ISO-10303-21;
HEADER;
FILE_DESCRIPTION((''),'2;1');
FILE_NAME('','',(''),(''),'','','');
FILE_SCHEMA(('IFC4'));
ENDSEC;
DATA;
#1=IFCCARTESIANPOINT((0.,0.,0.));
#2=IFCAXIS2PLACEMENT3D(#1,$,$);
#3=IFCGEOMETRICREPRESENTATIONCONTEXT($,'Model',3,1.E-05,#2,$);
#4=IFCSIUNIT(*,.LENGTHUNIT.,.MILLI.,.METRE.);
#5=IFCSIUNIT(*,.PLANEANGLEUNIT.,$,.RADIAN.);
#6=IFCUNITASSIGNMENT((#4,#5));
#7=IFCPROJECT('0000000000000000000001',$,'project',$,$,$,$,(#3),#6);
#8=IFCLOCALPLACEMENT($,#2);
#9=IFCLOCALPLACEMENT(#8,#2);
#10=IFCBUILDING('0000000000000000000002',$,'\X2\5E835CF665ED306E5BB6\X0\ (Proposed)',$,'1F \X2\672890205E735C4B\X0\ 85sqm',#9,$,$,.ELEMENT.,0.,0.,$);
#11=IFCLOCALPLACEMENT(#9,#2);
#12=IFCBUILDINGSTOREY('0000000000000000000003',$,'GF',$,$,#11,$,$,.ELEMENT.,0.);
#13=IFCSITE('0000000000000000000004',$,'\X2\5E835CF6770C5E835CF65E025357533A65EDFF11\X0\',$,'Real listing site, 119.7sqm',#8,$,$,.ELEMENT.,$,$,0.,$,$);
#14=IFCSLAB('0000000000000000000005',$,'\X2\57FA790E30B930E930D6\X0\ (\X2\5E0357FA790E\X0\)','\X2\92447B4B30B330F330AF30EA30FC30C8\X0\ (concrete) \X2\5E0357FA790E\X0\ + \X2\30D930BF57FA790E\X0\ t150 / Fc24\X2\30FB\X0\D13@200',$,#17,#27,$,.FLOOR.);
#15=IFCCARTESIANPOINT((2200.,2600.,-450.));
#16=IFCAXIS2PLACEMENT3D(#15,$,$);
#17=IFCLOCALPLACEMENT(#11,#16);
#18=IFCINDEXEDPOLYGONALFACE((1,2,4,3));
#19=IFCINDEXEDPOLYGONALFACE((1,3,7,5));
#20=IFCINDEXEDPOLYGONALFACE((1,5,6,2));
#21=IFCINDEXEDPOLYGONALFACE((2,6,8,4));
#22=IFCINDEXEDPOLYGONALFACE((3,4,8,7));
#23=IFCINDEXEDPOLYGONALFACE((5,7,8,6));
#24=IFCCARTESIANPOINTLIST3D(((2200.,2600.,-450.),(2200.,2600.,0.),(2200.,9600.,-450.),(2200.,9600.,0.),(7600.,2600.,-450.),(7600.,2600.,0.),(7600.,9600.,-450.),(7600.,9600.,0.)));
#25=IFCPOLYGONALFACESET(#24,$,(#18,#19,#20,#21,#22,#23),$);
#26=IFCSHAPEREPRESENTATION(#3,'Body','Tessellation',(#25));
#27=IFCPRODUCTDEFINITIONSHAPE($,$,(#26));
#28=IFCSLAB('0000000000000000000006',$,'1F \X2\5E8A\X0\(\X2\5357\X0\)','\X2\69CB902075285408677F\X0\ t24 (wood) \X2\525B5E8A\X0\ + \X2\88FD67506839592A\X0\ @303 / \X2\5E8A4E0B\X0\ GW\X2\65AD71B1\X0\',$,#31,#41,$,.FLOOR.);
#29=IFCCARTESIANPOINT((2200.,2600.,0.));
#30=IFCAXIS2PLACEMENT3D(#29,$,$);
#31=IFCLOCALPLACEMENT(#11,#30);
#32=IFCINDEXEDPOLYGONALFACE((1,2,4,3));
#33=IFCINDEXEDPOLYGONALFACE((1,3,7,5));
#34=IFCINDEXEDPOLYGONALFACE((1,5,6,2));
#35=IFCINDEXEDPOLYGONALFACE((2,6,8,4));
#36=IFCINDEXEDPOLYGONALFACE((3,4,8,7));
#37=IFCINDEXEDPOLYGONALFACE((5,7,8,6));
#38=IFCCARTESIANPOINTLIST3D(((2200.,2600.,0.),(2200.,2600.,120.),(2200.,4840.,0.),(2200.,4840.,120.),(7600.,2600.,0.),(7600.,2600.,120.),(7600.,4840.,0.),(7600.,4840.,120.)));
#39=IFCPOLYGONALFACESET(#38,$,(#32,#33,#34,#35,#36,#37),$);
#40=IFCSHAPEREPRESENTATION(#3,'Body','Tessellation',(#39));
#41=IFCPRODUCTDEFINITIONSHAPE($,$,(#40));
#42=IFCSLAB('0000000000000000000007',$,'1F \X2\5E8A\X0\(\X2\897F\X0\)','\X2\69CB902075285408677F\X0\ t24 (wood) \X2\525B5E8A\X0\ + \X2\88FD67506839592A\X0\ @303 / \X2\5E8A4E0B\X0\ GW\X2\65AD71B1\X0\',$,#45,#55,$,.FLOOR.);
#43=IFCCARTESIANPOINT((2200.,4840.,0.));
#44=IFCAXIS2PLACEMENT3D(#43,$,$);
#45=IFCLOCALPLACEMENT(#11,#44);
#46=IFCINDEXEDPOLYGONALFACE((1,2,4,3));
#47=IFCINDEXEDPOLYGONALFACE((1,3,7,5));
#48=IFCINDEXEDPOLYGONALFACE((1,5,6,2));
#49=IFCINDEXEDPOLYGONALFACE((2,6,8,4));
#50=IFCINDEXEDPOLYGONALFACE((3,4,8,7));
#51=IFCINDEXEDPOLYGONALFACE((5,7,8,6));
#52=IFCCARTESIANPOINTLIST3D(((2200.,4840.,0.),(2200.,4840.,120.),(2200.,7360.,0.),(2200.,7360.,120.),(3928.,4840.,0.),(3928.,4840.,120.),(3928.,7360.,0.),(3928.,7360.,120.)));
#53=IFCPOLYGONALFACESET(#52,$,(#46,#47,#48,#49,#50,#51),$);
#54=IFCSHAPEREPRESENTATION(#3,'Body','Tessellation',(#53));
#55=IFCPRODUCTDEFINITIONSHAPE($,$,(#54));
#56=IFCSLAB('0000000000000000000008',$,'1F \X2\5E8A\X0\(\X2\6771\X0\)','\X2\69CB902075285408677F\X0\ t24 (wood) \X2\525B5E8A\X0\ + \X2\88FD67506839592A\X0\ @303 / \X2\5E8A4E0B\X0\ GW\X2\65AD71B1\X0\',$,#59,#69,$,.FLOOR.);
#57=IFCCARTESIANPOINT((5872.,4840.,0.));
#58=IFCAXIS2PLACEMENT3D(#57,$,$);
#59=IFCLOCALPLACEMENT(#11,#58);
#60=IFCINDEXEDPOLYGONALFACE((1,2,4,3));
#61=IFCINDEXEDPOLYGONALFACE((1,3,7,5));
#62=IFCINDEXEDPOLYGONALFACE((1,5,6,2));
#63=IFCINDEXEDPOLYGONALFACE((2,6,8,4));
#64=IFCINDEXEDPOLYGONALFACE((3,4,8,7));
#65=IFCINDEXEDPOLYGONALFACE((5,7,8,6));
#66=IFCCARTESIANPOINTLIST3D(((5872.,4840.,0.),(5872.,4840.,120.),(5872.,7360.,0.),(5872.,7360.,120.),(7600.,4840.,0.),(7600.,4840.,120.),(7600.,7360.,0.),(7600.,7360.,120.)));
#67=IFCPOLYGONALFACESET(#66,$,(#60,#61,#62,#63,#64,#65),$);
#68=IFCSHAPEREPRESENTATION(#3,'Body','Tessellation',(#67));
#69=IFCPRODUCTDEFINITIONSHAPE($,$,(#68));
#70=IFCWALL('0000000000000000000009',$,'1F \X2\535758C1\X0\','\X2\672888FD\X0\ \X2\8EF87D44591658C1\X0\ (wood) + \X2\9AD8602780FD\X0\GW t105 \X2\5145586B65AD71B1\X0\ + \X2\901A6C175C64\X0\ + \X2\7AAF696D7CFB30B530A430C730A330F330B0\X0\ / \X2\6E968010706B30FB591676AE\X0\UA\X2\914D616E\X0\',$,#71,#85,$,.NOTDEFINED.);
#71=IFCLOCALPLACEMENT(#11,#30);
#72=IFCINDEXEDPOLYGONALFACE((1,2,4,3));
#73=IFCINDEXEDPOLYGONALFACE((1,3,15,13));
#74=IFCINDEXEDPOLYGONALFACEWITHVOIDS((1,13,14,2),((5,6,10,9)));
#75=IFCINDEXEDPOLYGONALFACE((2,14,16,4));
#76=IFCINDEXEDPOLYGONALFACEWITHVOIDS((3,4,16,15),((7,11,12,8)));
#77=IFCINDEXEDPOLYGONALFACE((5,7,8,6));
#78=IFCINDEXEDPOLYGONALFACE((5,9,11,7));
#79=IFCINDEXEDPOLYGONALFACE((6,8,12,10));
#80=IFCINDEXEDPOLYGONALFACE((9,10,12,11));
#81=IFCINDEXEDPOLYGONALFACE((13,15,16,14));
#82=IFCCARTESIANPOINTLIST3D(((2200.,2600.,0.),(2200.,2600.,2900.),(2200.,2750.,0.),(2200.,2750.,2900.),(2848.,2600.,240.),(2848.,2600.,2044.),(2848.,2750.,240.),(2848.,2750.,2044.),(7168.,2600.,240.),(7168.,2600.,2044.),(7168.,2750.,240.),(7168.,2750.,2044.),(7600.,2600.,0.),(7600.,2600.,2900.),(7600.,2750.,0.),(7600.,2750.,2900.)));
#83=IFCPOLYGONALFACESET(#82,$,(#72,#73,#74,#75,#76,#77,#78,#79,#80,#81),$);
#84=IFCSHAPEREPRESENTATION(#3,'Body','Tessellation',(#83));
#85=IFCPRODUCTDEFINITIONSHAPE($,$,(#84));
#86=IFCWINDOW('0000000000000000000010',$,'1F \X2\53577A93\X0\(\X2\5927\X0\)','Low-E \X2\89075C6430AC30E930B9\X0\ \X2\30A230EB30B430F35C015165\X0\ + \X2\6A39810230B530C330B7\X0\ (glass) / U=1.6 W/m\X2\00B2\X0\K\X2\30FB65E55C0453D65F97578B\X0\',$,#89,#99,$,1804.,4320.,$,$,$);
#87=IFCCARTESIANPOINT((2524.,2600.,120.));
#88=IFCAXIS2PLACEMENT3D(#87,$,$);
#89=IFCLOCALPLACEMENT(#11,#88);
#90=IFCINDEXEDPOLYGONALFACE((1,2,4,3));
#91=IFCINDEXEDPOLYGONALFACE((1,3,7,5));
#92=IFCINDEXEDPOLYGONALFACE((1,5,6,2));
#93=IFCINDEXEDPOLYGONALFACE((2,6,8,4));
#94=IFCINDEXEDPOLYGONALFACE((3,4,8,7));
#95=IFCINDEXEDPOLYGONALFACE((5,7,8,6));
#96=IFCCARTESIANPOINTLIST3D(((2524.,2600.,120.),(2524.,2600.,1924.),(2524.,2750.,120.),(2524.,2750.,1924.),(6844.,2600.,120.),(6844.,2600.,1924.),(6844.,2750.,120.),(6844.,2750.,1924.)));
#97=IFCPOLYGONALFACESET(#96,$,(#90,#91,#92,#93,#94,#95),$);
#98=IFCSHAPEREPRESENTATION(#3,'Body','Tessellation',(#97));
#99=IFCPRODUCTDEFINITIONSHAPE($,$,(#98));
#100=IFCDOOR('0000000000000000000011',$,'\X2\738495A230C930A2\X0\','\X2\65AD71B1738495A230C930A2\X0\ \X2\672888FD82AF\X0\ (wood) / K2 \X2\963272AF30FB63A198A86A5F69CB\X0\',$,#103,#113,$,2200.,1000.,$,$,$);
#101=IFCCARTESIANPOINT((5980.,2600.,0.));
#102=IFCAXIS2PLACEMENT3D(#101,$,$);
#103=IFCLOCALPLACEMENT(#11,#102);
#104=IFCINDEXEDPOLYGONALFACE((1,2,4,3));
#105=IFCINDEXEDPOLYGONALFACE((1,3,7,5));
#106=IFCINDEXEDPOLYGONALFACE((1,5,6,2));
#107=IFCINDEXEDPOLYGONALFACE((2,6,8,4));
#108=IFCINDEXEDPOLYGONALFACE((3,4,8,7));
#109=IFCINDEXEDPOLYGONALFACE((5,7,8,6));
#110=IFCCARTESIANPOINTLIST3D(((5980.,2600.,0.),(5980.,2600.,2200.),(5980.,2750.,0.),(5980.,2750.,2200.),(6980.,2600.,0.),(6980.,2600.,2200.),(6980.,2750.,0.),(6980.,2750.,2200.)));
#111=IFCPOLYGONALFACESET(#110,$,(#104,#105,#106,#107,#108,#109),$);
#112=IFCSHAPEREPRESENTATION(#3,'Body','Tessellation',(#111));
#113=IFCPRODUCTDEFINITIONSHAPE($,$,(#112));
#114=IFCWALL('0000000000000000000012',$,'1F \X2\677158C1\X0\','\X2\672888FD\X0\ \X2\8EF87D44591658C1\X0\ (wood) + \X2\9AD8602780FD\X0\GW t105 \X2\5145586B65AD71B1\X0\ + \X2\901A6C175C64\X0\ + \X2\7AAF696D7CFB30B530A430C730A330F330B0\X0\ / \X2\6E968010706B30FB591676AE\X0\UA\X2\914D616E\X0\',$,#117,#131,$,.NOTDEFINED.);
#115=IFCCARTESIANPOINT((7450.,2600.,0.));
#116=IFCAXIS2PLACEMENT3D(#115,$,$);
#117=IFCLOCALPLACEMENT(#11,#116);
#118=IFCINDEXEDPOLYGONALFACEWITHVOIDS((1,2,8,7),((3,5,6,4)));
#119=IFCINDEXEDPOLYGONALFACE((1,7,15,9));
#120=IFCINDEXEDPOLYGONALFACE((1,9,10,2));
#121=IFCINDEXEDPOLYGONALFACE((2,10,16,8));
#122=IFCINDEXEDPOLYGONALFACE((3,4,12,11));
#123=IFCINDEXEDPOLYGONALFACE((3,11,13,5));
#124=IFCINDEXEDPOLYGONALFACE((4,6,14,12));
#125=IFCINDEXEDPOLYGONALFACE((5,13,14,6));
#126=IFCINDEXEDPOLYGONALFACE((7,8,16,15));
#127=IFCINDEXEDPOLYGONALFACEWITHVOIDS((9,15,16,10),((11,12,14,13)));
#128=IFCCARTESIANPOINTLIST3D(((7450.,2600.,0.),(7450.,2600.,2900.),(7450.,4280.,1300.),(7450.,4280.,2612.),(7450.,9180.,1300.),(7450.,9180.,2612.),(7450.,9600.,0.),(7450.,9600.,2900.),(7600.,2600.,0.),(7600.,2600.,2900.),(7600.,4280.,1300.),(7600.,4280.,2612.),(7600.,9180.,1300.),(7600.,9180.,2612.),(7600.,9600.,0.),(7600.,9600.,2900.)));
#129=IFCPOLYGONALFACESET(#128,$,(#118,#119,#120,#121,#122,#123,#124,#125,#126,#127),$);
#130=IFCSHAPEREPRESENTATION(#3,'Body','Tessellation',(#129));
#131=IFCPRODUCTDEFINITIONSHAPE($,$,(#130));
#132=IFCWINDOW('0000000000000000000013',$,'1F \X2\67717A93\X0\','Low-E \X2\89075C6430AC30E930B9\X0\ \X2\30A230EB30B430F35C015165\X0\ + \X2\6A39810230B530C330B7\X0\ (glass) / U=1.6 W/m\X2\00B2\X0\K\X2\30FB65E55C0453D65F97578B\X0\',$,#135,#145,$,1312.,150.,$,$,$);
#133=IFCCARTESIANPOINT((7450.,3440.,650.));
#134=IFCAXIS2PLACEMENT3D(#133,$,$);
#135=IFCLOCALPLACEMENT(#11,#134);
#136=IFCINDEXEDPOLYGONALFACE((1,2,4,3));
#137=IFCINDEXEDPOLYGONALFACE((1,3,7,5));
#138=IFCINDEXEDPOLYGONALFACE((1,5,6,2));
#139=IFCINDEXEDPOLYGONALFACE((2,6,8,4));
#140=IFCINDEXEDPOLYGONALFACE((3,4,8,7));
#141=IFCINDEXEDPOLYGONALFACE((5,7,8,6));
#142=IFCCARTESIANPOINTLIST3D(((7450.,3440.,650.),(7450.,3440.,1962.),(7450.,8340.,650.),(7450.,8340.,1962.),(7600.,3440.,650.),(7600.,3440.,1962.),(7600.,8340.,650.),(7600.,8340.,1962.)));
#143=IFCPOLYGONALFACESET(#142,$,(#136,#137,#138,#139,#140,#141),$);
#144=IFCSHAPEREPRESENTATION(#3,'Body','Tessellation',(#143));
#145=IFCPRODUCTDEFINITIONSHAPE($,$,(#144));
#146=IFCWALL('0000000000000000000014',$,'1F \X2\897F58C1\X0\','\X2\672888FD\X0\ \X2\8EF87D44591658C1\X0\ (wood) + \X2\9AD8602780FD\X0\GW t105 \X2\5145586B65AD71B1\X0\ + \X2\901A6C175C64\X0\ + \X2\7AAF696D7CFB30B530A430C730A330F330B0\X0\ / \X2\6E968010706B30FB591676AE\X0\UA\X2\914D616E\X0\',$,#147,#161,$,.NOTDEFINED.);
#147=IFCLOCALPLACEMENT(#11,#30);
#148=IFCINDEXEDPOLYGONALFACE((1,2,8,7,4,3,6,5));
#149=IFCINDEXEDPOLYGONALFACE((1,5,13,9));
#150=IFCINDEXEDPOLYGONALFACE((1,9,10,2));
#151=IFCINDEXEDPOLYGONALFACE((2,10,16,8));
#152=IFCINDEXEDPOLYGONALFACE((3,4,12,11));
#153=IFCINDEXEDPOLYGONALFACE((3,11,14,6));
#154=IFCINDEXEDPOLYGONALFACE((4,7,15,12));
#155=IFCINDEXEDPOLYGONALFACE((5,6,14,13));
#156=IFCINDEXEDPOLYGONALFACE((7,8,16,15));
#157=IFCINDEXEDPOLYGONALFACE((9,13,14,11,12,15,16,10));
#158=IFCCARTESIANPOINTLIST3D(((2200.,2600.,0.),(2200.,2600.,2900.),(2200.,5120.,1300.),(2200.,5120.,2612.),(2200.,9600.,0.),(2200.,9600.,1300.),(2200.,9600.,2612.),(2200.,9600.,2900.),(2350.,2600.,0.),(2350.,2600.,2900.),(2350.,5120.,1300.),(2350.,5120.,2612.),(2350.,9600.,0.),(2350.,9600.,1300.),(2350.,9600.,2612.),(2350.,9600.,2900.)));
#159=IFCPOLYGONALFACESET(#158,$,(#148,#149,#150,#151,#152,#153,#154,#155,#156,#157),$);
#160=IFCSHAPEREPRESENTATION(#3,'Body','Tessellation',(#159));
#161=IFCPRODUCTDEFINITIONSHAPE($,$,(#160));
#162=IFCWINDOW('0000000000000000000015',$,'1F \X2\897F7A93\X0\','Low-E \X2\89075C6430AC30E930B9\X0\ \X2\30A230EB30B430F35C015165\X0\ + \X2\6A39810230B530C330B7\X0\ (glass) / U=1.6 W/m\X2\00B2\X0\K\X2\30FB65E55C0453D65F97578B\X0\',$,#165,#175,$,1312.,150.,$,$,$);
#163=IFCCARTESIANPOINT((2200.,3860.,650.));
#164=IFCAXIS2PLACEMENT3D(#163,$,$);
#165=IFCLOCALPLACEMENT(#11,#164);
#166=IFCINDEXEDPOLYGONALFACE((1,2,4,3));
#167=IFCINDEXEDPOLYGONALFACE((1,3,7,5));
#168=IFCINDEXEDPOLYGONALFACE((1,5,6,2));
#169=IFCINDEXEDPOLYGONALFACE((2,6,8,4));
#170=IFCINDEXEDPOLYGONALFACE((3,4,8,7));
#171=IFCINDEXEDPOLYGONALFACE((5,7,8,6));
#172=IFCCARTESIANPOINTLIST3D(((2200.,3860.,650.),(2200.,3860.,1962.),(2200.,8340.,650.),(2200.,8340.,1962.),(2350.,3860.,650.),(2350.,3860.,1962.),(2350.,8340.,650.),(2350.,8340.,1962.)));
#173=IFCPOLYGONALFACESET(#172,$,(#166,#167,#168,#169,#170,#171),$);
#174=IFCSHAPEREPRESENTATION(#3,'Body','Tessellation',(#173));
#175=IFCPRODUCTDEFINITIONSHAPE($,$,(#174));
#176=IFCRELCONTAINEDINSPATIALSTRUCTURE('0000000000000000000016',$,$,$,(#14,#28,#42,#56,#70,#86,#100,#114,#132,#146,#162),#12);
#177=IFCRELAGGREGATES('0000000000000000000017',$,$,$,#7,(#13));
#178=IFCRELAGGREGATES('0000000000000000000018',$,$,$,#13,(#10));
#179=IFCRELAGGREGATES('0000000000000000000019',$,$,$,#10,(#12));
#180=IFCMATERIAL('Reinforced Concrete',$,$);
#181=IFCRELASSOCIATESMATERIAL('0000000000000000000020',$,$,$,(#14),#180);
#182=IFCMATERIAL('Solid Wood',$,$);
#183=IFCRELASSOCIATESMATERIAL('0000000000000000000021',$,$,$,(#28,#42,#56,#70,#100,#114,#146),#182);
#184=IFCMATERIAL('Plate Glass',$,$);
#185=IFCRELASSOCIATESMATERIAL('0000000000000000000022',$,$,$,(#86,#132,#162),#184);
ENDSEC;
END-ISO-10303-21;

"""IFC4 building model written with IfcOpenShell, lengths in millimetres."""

from ifc_helpers import new_model, si_unit, frame, frame_2d, origin, place, context, project, spatial, rectangle, extrude, material, element, fill, save


model = new_model("IFC4")

# Units and contexts
model_context = context("Model", 3, precision=1e-05, world=origin())
ifc_project = project(units=[si_unit("LENGTHUNIT", "METRE", prefix="MILLI"), si_unit("PLANEANGLEUNIT", "RADIAN")], contexts=[model_context])

# Site, building, storey
site_placement = place(None, origin())
site = spatial("IfcSite", under=ifc_project, at=site_placement, Name="広島県広島市南区旭１", ObjectType="Real listing site, 119.7sqm", CompositionType="ELEMENT", RefElevation=0.0)
building_placement = place(site_placement, origin())
building = spatial("IfcBuilding", under=site, at=building_placement, Name="広島旭の家 (Proposed)", ObjectType="1F 木造平屋 85sqm", CompositionType="ELEMENT", ElevationOfRefHeight=0.0, ElevationOfTerrain=0.0)
storey_placement = place(building_placement, origin())
storey = spatial("IfcBuildingStorey", under=building, at=storey_placement, Name="GF", CompositionType="ELEMENT", Elevation=0.0)

# Slabs
ifc_material_1 = material(Name="Reinforced Concrete")
slab_1_placement = place(storey_placement, frame((2200.0, 2600.0, -450.0)))
element("IfcSlab", 1, at=slab_1_placement, inside=storey, material=ifc_material_1, Name="基礎スラブ (布基礎)", Description="鉄筋コンクリート (concrete) 布基礎 + ベタ基礎 t150 / Fc24・D13@200", PredefinedType="FLOOR", context=model_context, shape_type="SweptSolid", body=[
    extrude(rectangle(XDim=5400.0, YDim=7000.0, at=frame_2d((2700.0, 3500.0))), frame((2200.0, 2600.0, -450.0)), (0.0, 0.0, 1.0), 450.0),
])
ifc_material_2 = material(Name="Solid Wood")
slab_2_placement = place(storey_placement, frame((2200.0, 2600.0, 0.0)))
element("IfcSlab", 2, at=slab_2_placement, inside=storey, material=ifc_material_2, Name="1F 床(南)", Description="構造用合板 t24 (wood) 剛床 + 製材根太 @303 / 床下 GW断熱", PredefinedType="FLOOR", context=model_context, shape_type="SweptSolid", body=[
    extrude(rectangle(XDim=5400.0, YDim=2240.0, at=frame_2d((2700.0, 1120.0))), frame((2200.0, 2600.0, 0.0)), (0.0, 0.0, 1.0), 120.0),
])
slab_3_placement = place(storey_placement, frame((2200.0, 4840.0, 0.0)))
element("IfcSlab", 3, at=slab_3_placement, inside=storey, material=ifc_material_2, Name="1F 床(西)", Description="構造用合板 t24 (wood) 剛床 + 製材根太 @303 / 床下 GW断熱", PredefinedType="FLOOR", context=model_context, shape_type="SweptSolid", body=[
    extrude(rectangle(XDim=1728.0, YDim=2520.0, at=frame_2d((864.0, 1260.0))), frame((2200.0, 4840.0, 0.0)), (0.0, 0.0, 1.0), 120.0),
])
slab_4_placement = place(storey_placement, frame((5872.0, 4840.0, 0.0)))
element("IfcSlab", 4, at=slab_4_placement, inside=storey, material=ifc_material_2, Name="1F 床(東)", Description="構造用合板 t24 (wood) 剛床 + 製材根太 @303 / 床下 GW断熱", PredefinedType="FLOOR", context=model_context, shape_type="SweptSolid", body=[
    extrude(rectangle(XDim=1728.0, YDim=2520.0, at=frame_2d((864.0, 1260.0))), frame((5872.0, 4840.0, 0.0)), (0.0, 0.0, 1.0), 120.0),
])

# Wall, openings, window, door
wall_1_placement = place(storey_placement, frame((2200.0, 2600.0, 0.0)))
wall_1 = element("IfcWall", 5, at=wall_1_placement, inside=storey, material=ifc_material_2, Name="1F 南壁", Description="木製 軸組外壁 (wood) + 高性能GW t105 充填断熱 + 通気層 + 窯業系サイディング / 準耐火・外皮UA配慮", PredefinedType="NOTDEFINED", context=model_context, shape_type="SweptSolid", body=[
    extrude(rectangle(XDim=5400.0, YDim=150.0, at=frame_2d((2700.0, 75.0))), frame((2200.0, 2600.0, 0.0)), (0.0, 0.0, 1.0), 2900.0),
])
opening_1_placement = place(storey_placement, frame((2524.0, 2600.0, 120.0)))
opening_1 = element("IfcOpeningElement", 6, at=opening_1_placement, cuts=wall_1, PredefinedType="NOTDEFINED", context=model_context, shape_type="SweptSolid", body=[
    extrude(rectangle(XDim=4320.0, YDim=150.0, at=frame_2d((2160.0, 75.0))), frame((2524.0, 2600.0, 120.0)), (0.0, 0.0, 1.0), 1804.0),
])
opening_2_placement = place(storey_placement, frame((5980.0, 2600.0, 0.0)))
opening_2 = element("IfcOpeningElement", 7, at=opening_2_placement, cuts=wall_1, PredefinedType="NOTDEFINED", context=model_context, shape_type="SweptSolid", body=[
    extrude(rectangle(XDim=1000.0, YDim=150.0, at=frame_2d((500.0, 75.0))), frame((5980.0, 2600.0, 0.0)), (0.0, 0.0, 1.0), 2200.0),
])
ifc_material_3 = material(Name="Plate Glass")
window_1_placement = place(storey_placement, frame((2524.0, 2600.0, 120.0)))
window_1 = element("IfcWindow", 8, at=window_1_placement, inside=storey, material=ifc_material_3, Name="1F 南窓(大)", Description="Low-E 複層ガラス アルゴン封入 + 樹脂サッシ (glass) / U=1.6 W/m²K・日射取得型", OverallHeight=1804.0, OverallWidth=4320.0, context=model_context, shape_type="SweptSolid", body=[
    extrude(rectangle(XDim=4320.0, YDim=150.0, at=frame_2d((2160.0, 75.0))), frame((2524.0, 2600.0, 120.0)), (0.0, 0.0, 1.0), 1804.0),
])
fill(opening_1, window_1)
door_placement = place(storey_placement, frame((5980.0, 2600.0, 0.0)))
door = element("IfcDoor", 9, at=door_placement, inside=storey, material=ifc_material_2, Name="玄関ドア", Description="断熱玄関ドア 木製芯 (wood) / K2 防犯・採風機構", OverallHeight=2200.0, OverallWidth=1000.0, context=model_context, shape_type="SweptSolid", body=[
    extrude(rectangle(XDim=1000.0, YDim=150.0, at=frame_2d((500.0, 75.0))), frame((5980.0, 2600.0, 0.0)), (0.0, 0.0, 1.0), 2200.0),
])
fill(opening_2, door)

# Walls, openings, windows
wall_2_placement = place(storey_placement, frame((7450.0, 2600.0, 0.0)))
wall_2 = element("IfcWall", 10, at=wall_2_placement, inside=storey, material=ifc_material_2, Name="1F 東壁", Description="木製 軸組外壁 (wood) + 高性能GW t105 充填断熱 + 通気層 + 窯業系サイディング / 準耐火・外皮UA配慮", PredefinedType="NOTDEFINED", context=model_context, shape_type="SweptSolid", body=[
    extrude(rectangle(XDim=150.0, YDim=7000.0, at=frame_2d((75.0, 3500.0))), frame((7450.0, 2600.0, 0.0)), (0.0, 0.0, 1.0), 2900.0),
])
opening_3_placement = place(storey_placement, frame((7450.0, 3440.0, 650.0)))
opening_3 = element("IfcOpeningElement", 11, at=opening_3_placement, cuts=wall_2, PredefinedType="NOTDEFINED", context=model_context, shape_type="SweptSolid", body=[
    extrude(rectangle(XDim=150.0, YDim=4900.0, at=frame_2d((75.0, 2450.0))), frame((7450.0, 3440.0, 650.0)), (0.0, 0.0, 1.0), 1312.0),
])
window_2_placement = place(storey_placement, frame((7450.0, 3440.0, 650.0)))
window_2 = element("IfcWindow", 12, at=window_2_placement, inside=storey, material=ifc_material_3, Name="1F 東窓", Description="Low-E 複層ガラス アルゴン封入 + 樹脂サッシ (glass) / U=1.6 W/m²K・日射取得型", OverallHeight=1312.0, OverallWidth=150.0, context=model_context, shape_type="SweptSolid", body=[
    extrude(rectangle(XDim=150.0, YDim=4900.0, at=frame_2d((75.0, 2450.0))), frame((7450.0, 3440.0, 650.0)), (0.0, 0.0, 1.0), 1312.0),
])
fill(opening_3, window_2)
wall_3_placement = place(storey_placement, frame((2200.0, 2600.0, 0.0)))
wall_3 = element("IfcWall", 13, at=wall_3_placement, inside=storey, material=ifc_material_2, Name="1F 西壁", Description="木製 軸組外壁 (wood) + 高性能GW t105 充填断熱 + 通気層 + 窯業系サイディング / 準耐火・外皮UA配慮", PredefinedType="NOTDEFINED", context=model_context, shape_type="SweptSolid", body=[
    extrude(rectangle(XDim=150.0, YDim=7000.0, at=frame_2d((75.0, 3500.0))), frame((2200.0, 2600.0, 0.0)), (0.0, 0.0, 1.0), 2900.0),
])
opening_4_placement = place(storey_placement, frame((2200.0, 3860.0, 650.0)))
opening_4 = element("IfcOpeningElement", 14, at=opening_4_placement, cuts=wall_3, PredefinedType="NOTDEFINED", context=model_context, shape_type="SweptSolid", body=[
    extrude(rectangle(XDim=150.0, YDim=4480.0, at=frame_2d((75.0, 2240.0))), frame((2200.0, 3860.0, 650.0)), (0.0, 0.0, 1.0), 1312.0),
])
window_3_placement = place(storey_placement, frame((2200.0, 3860.0, 650.0)))
window_3 = element("IfcWindow", 15, at=window_3_placement, inside=storey, material=ifc_material_3, Name="1F 西窓", Description="Low-E 複層ガラス アルゴン封入 + 樹脂サッシ (glass) / U=1.6 W/m²K・日射取得型", OverallHeight=1312.0, OverallWidth=150.0, context=model_context, shape_type="SweptSolid", body=[
    extrude(rectangle(XDim=150.0, YDim=4480.0, at=frame_2d((75.0, 2240.0))), frame((2200.0, 3860.0, 650.0)), (0.0, 0.0, 1.0), 1312.0),
])
fill(opening_4, window_3)

save(model, "model.ifc")
